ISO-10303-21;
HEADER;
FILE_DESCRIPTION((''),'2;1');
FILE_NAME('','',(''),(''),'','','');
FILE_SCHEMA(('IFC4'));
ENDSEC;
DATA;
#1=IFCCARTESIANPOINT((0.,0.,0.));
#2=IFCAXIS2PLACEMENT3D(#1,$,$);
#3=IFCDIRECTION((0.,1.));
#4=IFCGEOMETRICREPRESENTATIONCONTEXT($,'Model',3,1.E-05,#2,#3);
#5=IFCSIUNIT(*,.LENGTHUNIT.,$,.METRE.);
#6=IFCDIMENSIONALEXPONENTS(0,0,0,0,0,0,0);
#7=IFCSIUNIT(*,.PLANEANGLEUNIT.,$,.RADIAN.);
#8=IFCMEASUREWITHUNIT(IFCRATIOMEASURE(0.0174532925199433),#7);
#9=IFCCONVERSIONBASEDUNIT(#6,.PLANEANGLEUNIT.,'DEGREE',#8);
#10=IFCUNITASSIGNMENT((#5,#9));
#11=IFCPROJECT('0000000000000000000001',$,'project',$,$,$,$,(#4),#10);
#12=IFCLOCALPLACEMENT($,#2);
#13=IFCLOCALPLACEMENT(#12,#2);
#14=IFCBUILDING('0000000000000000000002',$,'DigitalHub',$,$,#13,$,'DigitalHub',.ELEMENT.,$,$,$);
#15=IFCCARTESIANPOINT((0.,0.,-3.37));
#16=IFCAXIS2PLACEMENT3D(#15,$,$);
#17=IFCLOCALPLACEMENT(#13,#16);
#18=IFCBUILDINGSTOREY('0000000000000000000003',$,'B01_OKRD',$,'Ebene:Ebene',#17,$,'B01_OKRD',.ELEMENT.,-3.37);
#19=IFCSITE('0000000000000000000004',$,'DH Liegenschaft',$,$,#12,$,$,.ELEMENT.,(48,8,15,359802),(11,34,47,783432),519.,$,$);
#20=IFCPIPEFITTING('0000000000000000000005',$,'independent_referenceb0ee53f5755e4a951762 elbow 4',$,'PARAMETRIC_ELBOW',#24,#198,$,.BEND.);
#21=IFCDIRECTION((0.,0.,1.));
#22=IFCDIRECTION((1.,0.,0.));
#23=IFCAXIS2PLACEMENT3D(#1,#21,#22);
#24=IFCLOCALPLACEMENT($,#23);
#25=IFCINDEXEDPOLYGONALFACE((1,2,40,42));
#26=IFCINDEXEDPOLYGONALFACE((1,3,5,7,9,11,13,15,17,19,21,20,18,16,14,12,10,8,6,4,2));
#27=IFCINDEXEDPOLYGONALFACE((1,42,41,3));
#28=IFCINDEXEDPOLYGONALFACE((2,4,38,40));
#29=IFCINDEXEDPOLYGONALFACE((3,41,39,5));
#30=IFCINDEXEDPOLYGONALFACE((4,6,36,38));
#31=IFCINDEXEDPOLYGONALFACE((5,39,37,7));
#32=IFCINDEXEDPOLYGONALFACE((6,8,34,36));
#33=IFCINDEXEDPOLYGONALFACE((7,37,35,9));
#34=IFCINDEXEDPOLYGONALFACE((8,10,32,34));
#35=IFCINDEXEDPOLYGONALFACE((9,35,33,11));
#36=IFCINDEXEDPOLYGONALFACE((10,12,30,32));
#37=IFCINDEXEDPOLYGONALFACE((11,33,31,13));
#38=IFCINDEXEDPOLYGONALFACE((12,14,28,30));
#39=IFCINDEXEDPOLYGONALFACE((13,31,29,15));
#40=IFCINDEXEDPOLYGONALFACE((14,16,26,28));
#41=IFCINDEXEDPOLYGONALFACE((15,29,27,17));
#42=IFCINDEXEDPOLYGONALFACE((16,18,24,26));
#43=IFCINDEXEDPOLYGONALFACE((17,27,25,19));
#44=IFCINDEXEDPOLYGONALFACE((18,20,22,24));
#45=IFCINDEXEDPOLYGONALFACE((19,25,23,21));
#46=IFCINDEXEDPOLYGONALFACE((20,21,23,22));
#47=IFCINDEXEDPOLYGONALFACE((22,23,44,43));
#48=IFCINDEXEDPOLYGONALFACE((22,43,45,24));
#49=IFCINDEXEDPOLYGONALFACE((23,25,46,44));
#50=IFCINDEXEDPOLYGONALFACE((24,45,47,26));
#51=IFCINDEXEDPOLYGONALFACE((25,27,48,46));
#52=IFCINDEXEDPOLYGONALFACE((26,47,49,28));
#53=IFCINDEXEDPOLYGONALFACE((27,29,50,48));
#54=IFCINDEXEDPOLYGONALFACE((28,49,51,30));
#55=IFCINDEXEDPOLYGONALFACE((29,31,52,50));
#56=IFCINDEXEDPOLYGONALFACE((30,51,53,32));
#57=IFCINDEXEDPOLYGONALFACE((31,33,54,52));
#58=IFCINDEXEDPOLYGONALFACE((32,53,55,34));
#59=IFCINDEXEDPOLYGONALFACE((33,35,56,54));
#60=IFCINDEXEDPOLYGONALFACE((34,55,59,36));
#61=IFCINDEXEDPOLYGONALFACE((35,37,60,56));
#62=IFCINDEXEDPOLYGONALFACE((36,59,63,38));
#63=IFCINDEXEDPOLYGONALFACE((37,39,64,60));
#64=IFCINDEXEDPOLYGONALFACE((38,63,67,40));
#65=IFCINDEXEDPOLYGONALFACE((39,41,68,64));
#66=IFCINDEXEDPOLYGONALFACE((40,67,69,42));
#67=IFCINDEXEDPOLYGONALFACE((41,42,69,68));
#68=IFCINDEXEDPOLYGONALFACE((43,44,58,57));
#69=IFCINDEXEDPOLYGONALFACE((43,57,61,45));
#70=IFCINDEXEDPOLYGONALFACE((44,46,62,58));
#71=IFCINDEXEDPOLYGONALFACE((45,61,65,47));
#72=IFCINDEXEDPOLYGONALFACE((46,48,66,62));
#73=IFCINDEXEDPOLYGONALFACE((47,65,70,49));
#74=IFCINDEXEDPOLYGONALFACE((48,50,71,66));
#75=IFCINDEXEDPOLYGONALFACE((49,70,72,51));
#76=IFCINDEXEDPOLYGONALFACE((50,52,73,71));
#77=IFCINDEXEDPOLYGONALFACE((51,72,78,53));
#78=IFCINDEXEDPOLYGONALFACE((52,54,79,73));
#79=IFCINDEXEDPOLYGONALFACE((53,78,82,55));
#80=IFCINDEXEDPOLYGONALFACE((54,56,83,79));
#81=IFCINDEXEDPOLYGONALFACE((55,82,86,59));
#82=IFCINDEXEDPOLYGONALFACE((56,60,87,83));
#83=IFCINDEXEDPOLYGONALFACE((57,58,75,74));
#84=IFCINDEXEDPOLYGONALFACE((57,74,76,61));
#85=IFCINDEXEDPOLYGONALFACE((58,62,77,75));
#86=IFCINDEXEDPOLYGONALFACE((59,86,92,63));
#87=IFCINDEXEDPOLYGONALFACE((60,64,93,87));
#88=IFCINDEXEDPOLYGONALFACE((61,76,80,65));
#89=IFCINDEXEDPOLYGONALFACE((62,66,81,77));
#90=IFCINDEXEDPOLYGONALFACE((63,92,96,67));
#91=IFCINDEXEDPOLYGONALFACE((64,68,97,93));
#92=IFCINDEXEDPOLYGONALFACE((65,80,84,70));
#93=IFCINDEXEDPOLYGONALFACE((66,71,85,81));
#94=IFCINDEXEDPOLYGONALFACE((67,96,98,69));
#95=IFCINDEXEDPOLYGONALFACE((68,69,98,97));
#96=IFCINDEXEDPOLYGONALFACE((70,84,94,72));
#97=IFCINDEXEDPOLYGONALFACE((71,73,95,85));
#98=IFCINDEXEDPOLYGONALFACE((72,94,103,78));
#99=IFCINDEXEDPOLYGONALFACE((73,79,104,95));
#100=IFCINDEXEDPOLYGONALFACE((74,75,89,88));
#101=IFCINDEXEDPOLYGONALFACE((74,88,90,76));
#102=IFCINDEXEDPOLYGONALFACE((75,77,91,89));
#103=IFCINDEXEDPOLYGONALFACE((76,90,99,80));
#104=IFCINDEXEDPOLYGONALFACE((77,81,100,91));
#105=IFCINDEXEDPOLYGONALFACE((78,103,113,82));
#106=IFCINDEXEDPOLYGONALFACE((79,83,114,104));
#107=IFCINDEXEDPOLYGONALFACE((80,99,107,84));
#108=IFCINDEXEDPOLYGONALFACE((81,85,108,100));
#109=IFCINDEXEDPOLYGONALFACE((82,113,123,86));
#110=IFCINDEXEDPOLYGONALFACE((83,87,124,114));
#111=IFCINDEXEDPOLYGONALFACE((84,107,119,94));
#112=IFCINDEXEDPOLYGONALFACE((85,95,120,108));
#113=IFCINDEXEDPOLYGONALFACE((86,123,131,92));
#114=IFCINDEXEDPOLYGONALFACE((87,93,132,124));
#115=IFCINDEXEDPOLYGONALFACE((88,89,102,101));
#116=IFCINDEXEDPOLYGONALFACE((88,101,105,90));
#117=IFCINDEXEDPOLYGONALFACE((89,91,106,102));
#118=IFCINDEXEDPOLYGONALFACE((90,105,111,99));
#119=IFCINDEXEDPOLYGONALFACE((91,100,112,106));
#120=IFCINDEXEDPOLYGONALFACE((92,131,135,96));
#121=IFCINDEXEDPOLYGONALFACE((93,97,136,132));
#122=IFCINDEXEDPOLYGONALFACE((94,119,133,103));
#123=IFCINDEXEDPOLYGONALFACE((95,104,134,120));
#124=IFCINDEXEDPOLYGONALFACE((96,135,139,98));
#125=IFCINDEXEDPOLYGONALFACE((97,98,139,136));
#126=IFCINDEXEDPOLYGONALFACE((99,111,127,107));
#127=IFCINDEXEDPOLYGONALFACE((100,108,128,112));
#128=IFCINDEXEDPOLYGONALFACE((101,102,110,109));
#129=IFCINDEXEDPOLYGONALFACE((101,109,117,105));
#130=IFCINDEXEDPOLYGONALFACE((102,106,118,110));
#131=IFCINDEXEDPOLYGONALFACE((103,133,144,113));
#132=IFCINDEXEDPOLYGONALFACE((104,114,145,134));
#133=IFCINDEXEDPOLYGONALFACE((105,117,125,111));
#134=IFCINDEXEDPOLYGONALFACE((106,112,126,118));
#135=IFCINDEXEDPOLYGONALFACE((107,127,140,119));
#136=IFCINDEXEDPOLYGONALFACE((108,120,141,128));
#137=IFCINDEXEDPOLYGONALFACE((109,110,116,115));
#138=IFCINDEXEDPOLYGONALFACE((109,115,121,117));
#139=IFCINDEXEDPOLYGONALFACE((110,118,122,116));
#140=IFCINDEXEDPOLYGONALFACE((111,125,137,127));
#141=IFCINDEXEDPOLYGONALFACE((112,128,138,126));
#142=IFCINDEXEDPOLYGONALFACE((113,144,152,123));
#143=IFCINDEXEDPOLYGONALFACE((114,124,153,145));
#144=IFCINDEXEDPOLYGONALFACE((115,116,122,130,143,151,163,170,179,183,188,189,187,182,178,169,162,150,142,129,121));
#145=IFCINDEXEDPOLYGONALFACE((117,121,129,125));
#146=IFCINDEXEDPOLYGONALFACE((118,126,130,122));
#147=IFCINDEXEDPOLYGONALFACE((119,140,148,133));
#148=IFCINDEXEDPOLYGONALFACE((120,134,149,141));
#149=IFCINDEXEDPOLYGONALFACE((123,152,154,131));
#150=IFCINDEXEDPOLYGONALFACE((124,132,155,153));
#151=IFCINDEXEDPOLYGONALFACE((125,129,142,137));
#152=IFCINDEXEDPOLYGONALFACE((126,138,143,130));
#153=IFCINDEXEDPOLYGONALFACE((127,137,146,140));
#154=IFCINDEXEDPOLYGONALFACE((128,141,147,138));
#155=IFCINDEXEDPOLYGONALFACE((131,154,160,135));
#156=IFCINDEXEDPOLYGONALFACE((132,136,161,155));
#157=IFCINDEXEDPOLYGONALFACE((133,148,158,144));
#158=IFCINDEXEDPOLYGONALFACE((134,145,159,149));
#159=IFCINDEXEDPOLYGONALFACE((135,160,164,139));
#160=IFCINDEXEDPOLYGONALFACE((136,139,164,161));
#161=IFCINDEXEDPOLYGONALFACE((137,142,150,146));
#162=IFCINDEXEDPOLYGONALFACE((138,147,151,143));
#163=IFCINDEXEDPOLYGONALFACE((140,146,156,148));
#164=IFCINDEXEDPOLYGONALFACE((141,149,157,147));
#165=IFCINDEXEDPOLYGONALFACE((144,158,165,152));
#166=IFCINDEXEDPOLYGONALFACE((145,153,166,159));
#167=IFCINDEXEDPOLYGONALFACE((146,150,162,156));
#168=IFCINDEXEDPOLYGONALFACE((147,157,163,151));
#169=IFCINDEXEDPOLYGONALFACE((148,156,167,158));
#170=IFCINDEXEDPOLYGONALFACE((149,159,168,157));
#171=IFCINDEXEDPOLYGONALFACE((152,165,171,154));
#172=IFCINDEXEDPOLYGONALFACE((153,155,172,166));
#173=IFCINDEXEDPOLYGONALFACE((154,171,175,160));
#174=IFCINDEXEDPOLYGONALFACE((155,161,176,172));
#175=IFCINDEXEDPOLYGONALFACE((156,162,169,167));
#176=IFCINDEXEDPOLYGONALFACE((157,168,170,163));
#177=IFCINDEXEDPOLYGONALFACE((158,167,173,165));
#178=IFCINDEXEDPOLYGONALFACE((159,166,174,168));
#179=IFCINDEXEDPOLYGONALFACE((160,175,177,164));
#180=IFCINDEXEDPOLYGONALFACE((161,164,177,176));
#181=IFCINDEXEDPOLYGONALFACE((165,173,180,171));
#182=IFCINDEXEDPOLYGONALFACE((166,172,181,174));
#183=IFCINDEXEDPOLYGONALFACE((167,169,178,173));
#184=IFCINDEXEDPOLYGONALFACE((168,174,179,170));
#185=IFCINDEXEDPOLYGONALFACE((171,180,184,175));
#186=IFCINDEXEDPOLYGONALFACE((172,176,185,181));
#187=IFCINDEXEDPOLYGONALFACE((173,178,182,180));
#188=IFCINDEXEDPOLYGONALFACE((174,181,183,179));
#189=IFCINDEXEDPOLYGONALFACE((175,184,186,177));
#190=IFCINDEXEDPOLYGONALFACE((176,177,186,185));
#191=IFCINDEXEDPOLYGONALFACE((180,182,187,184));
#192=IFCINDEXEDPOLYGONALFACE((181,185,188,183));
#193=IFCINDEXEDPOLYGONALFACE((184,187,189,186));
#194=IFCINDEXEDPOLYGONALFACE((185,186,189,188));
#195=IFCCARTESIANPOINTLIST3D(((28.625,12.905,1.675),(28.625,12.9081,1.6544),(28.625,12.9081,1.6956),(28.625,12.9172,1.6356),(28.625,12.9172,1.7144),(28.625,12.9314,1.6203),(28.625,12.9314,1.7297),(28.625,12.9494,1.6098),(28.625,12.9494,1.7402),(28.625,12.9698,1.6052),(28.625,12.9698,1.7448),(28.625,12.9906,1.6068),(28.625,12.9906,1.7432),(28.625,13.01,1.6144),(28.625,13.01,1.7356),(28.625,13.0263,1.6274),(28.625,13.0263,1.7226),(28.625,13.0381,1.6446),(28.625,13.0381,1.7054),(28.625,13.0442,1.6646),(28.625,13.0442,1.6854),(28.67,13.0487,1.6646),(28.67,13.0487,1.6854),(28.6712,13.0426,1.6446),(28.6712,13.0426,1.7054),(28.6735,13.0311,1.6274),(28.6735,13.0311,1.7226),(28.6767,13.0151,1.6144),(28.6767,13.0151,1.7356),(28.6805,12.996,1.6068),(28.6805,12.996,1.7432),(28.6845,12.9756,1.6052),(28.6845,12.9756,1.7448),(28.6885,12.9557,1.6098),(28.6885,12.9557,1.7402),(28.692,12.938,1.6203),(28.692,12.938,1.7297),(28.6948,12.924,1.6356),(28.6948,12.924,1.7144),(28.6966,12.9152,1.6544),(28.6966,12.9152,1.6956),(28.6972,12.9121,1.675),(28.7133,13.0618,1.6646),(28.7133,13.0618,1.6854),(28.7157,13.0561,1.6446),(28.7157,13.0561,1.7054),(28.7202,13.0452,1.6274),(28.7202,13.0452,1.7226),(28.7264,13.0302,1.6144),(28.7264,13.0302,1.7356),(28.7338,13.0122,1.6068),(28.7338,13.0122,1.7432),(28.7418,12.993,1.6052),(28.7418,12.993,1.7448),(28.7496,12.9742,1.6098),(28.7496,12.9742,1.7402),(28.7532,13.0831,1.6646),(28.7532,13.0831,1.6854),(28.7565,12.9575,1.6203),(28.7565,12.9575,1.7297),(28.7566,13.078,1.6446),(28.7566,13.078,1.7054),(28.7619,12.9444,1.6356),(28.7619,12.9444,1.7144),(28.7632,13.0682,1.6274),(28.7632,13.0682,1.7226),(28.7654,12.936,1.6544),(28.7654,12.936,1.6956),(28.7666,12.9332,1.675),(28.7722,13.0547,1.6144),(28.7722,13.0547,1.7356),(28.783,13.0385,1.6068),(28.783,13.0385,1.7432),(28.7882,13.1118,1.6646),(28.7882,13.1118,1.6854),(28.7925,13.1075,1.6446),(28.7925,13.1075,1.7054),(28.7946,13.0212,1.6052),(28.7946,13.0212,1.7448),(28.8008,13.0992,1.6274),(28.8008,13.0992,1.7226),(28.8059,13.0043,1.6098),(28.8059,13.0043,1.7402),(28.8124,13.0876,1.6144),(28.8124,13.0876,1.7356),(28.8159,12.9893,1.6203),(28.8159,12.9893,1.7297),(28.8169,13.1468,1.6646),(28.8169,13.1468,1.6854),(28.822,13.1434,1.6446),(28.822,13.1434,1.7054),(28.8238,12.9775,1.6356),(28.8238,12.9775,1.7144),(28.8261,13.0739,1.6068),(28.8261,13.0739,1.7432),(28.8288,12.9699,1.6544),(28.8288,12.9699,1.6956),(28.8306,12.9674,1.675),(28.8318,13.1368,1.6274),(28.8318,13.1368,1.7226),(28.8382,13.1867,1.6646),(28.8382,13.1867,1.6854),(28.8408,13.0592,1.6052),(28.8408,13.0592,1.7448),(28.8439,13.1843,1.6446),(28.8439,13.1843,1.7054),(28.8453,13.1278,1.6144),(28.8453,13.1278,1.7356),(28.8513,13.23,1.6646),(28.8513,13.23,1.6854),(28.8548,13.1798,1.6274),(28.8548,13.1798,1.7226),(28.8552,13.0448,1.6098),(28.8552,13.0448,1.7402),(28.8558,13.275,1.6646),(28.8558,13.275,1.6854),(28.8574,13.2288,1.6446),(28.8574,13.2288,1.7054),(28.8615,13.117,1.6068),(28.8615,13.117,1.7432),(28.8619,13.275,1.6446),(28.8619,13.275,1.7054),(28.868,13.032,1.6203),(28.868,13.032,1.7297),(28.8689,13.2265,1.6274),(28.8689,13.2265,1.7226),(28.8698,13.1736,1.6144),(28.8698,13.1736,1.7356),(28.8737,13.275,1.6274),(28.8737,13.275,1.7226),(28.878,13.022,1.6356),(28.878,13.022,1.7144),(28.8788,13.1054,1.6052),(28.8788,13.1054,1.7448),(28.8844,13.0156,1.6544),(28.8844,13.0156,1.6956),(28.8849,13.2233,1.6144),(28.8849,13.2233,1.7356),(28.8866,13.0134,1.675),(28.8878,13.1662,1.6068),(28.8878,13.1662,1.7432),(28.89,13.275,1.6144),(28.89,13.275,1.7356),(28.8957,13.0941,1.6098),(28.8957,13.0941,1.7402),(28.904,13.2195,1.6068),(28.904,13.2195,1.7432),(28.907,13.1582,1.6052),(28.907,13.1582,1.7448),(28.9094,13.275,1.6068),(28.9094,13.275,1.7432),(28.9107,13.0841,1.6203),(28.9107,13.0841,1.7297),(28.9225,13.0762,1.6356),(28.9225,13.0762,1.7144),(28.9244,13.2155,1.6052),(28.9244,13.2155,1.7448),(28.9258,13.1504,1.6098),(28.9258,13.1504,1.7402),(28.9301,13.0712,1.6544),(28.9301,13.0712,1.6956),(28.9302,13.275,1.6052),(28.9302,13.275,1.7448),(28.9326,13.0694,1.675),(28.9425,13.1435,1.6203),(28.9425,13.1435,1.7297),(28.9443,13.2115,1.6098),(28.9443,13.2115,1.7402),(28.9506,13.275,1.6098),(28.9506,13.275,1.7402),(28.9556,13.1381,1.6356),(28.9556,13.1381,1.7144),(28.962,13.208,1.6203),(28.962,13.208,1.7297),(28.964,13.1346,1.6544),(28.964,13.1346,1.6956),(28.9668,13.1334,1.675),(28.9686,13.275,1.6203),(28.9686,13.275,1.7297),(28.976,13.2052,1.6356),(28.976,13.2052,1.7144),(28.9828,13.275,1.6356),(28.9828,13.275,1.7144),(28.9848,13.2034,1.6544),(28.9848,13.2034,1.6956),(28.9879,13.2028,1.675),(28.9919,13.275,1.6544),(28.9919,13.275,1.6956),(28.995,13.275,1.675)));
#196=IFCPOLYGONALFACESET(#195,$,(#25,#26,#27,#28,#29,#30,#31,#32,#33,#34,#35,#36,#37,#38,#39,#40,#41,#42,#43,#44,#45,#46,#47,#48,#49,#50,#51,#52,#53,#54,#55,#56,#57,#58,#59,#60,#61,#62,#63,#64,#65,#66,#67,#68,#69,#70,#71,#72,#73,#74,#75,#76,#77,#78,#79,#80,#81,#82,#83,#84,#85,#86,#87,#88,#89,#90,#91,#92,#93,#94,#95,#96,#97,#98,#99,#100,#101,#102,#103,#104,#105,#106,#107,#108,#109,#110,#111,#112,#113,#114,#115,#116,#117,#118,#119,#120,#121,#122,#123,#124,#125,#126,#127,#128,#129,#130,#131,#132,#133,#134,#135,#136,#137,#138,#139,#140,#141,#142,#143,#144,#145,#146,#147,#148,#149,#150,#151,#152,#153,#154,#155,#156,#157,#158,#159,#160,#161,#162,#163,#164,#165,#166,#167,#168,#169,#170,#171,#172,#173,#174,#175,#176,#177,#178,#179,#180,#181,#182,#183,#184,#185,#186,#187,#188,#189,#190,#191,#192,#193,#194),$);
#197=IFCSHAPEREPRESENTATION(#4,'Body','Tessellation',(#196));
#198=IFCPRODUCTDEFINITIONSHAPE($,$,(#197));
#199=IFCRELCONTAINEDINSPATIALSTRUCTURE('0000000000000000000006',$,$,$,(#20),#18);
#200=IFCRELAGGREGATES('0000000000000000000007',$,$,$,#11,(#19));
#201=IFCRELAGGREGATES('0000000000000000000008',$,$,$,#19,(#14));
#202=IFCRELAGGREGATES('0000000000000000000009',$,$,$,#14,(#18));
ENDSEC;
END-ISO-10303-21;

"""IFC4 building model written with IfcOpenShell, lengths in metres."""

from ifc_helpers import new_model, entity, si_unit, converted_unit, direction, frame, origin, origin_with_axes, place, context, project, spatial, element, save


model = new_model("IFC4")

# Units and contexts
model_context = context("Model", 3, precision=1e-05, world=origin(), true_north=direction((0.0, 1.0)))
ifc_project = project(units=[si_unit("LENGTHUNIT", "METRE"), converted_unit("PLANEANGLEUNIT", "DEGREE", entity("IfcRatioMeasure", 0.0174532925199433), si_unit("PLANEANGLEUNIT", "RADIAN"), dimensions=[0, 0, 0, 0, 0, 0, 0])], contexts=[model_context])

# Site, building, storey
site_placement = place(None, frame((0.0, 0.0, 0.0)))
site = spatial("IfcSite", under=ifc_project, at=site_placement, Name="DH Liegenschaft", CompositionType="ELEMENT", RefLatitude=(48, 8, 15, 359802), RefLongitude=(11, 34, 47, 783432), RefElevation=519.0)
building_placement = place(site_placement, origin())
building = spatial("IfcBuilding", under=site, at=building_placement, Name="DigitalHub", LongName="DigitalHub", CompositionType="ELEMENT")
storey_placement = place(building_placement, frame((0.0, 0.0, -3.37)))
storey = spatial("IfcBuildingStorey", under=building, at=storey_placement, Name="B01_OKRD", ObjectType="Ebene:Ebene", LongName="B01_OKRD", CompositionType="ELEMENT", Elevation=-3.37)

# Pipe fitting
pipe_fitting_1_placement = place(None, origin_with_axes())
element("IfcPipeFitting", 1, at=pipe_fitting_1_placement, inside=storey, Name="independent_referenceb0ee53f5755e4a951762 elbow 4", ObjectType="PARAMETRIC_ELBOW", PredefinedType="BEND", context=model_context, shape_type="SweptSolid", body=[
    entity("IfcRevolvedAreaSolid", entity("IfcCircleProfileDef", "AREA", None, entity("IfcAxis2Placement2D", entity("IfcCartesianPoint", [0.3, 0.0])), 0.07), entity("IfcAxis2Placement3D", entity("IfcCartesianPoint", [28.625, 13.275, 1.675]), entity("IfcDirection", [1.0, 0.0, 0.0]), entity("IfcDirection", [0.0, -1.0, 0.0])), entity("IfcAxis1Placement", entity("IfcCartesianPoint", [0.0, 0.0, 0.0]), entity("IfcDirection", [0.0, -1.0, 0.0])), 90.0),
])

save(model, "model.ifc")
